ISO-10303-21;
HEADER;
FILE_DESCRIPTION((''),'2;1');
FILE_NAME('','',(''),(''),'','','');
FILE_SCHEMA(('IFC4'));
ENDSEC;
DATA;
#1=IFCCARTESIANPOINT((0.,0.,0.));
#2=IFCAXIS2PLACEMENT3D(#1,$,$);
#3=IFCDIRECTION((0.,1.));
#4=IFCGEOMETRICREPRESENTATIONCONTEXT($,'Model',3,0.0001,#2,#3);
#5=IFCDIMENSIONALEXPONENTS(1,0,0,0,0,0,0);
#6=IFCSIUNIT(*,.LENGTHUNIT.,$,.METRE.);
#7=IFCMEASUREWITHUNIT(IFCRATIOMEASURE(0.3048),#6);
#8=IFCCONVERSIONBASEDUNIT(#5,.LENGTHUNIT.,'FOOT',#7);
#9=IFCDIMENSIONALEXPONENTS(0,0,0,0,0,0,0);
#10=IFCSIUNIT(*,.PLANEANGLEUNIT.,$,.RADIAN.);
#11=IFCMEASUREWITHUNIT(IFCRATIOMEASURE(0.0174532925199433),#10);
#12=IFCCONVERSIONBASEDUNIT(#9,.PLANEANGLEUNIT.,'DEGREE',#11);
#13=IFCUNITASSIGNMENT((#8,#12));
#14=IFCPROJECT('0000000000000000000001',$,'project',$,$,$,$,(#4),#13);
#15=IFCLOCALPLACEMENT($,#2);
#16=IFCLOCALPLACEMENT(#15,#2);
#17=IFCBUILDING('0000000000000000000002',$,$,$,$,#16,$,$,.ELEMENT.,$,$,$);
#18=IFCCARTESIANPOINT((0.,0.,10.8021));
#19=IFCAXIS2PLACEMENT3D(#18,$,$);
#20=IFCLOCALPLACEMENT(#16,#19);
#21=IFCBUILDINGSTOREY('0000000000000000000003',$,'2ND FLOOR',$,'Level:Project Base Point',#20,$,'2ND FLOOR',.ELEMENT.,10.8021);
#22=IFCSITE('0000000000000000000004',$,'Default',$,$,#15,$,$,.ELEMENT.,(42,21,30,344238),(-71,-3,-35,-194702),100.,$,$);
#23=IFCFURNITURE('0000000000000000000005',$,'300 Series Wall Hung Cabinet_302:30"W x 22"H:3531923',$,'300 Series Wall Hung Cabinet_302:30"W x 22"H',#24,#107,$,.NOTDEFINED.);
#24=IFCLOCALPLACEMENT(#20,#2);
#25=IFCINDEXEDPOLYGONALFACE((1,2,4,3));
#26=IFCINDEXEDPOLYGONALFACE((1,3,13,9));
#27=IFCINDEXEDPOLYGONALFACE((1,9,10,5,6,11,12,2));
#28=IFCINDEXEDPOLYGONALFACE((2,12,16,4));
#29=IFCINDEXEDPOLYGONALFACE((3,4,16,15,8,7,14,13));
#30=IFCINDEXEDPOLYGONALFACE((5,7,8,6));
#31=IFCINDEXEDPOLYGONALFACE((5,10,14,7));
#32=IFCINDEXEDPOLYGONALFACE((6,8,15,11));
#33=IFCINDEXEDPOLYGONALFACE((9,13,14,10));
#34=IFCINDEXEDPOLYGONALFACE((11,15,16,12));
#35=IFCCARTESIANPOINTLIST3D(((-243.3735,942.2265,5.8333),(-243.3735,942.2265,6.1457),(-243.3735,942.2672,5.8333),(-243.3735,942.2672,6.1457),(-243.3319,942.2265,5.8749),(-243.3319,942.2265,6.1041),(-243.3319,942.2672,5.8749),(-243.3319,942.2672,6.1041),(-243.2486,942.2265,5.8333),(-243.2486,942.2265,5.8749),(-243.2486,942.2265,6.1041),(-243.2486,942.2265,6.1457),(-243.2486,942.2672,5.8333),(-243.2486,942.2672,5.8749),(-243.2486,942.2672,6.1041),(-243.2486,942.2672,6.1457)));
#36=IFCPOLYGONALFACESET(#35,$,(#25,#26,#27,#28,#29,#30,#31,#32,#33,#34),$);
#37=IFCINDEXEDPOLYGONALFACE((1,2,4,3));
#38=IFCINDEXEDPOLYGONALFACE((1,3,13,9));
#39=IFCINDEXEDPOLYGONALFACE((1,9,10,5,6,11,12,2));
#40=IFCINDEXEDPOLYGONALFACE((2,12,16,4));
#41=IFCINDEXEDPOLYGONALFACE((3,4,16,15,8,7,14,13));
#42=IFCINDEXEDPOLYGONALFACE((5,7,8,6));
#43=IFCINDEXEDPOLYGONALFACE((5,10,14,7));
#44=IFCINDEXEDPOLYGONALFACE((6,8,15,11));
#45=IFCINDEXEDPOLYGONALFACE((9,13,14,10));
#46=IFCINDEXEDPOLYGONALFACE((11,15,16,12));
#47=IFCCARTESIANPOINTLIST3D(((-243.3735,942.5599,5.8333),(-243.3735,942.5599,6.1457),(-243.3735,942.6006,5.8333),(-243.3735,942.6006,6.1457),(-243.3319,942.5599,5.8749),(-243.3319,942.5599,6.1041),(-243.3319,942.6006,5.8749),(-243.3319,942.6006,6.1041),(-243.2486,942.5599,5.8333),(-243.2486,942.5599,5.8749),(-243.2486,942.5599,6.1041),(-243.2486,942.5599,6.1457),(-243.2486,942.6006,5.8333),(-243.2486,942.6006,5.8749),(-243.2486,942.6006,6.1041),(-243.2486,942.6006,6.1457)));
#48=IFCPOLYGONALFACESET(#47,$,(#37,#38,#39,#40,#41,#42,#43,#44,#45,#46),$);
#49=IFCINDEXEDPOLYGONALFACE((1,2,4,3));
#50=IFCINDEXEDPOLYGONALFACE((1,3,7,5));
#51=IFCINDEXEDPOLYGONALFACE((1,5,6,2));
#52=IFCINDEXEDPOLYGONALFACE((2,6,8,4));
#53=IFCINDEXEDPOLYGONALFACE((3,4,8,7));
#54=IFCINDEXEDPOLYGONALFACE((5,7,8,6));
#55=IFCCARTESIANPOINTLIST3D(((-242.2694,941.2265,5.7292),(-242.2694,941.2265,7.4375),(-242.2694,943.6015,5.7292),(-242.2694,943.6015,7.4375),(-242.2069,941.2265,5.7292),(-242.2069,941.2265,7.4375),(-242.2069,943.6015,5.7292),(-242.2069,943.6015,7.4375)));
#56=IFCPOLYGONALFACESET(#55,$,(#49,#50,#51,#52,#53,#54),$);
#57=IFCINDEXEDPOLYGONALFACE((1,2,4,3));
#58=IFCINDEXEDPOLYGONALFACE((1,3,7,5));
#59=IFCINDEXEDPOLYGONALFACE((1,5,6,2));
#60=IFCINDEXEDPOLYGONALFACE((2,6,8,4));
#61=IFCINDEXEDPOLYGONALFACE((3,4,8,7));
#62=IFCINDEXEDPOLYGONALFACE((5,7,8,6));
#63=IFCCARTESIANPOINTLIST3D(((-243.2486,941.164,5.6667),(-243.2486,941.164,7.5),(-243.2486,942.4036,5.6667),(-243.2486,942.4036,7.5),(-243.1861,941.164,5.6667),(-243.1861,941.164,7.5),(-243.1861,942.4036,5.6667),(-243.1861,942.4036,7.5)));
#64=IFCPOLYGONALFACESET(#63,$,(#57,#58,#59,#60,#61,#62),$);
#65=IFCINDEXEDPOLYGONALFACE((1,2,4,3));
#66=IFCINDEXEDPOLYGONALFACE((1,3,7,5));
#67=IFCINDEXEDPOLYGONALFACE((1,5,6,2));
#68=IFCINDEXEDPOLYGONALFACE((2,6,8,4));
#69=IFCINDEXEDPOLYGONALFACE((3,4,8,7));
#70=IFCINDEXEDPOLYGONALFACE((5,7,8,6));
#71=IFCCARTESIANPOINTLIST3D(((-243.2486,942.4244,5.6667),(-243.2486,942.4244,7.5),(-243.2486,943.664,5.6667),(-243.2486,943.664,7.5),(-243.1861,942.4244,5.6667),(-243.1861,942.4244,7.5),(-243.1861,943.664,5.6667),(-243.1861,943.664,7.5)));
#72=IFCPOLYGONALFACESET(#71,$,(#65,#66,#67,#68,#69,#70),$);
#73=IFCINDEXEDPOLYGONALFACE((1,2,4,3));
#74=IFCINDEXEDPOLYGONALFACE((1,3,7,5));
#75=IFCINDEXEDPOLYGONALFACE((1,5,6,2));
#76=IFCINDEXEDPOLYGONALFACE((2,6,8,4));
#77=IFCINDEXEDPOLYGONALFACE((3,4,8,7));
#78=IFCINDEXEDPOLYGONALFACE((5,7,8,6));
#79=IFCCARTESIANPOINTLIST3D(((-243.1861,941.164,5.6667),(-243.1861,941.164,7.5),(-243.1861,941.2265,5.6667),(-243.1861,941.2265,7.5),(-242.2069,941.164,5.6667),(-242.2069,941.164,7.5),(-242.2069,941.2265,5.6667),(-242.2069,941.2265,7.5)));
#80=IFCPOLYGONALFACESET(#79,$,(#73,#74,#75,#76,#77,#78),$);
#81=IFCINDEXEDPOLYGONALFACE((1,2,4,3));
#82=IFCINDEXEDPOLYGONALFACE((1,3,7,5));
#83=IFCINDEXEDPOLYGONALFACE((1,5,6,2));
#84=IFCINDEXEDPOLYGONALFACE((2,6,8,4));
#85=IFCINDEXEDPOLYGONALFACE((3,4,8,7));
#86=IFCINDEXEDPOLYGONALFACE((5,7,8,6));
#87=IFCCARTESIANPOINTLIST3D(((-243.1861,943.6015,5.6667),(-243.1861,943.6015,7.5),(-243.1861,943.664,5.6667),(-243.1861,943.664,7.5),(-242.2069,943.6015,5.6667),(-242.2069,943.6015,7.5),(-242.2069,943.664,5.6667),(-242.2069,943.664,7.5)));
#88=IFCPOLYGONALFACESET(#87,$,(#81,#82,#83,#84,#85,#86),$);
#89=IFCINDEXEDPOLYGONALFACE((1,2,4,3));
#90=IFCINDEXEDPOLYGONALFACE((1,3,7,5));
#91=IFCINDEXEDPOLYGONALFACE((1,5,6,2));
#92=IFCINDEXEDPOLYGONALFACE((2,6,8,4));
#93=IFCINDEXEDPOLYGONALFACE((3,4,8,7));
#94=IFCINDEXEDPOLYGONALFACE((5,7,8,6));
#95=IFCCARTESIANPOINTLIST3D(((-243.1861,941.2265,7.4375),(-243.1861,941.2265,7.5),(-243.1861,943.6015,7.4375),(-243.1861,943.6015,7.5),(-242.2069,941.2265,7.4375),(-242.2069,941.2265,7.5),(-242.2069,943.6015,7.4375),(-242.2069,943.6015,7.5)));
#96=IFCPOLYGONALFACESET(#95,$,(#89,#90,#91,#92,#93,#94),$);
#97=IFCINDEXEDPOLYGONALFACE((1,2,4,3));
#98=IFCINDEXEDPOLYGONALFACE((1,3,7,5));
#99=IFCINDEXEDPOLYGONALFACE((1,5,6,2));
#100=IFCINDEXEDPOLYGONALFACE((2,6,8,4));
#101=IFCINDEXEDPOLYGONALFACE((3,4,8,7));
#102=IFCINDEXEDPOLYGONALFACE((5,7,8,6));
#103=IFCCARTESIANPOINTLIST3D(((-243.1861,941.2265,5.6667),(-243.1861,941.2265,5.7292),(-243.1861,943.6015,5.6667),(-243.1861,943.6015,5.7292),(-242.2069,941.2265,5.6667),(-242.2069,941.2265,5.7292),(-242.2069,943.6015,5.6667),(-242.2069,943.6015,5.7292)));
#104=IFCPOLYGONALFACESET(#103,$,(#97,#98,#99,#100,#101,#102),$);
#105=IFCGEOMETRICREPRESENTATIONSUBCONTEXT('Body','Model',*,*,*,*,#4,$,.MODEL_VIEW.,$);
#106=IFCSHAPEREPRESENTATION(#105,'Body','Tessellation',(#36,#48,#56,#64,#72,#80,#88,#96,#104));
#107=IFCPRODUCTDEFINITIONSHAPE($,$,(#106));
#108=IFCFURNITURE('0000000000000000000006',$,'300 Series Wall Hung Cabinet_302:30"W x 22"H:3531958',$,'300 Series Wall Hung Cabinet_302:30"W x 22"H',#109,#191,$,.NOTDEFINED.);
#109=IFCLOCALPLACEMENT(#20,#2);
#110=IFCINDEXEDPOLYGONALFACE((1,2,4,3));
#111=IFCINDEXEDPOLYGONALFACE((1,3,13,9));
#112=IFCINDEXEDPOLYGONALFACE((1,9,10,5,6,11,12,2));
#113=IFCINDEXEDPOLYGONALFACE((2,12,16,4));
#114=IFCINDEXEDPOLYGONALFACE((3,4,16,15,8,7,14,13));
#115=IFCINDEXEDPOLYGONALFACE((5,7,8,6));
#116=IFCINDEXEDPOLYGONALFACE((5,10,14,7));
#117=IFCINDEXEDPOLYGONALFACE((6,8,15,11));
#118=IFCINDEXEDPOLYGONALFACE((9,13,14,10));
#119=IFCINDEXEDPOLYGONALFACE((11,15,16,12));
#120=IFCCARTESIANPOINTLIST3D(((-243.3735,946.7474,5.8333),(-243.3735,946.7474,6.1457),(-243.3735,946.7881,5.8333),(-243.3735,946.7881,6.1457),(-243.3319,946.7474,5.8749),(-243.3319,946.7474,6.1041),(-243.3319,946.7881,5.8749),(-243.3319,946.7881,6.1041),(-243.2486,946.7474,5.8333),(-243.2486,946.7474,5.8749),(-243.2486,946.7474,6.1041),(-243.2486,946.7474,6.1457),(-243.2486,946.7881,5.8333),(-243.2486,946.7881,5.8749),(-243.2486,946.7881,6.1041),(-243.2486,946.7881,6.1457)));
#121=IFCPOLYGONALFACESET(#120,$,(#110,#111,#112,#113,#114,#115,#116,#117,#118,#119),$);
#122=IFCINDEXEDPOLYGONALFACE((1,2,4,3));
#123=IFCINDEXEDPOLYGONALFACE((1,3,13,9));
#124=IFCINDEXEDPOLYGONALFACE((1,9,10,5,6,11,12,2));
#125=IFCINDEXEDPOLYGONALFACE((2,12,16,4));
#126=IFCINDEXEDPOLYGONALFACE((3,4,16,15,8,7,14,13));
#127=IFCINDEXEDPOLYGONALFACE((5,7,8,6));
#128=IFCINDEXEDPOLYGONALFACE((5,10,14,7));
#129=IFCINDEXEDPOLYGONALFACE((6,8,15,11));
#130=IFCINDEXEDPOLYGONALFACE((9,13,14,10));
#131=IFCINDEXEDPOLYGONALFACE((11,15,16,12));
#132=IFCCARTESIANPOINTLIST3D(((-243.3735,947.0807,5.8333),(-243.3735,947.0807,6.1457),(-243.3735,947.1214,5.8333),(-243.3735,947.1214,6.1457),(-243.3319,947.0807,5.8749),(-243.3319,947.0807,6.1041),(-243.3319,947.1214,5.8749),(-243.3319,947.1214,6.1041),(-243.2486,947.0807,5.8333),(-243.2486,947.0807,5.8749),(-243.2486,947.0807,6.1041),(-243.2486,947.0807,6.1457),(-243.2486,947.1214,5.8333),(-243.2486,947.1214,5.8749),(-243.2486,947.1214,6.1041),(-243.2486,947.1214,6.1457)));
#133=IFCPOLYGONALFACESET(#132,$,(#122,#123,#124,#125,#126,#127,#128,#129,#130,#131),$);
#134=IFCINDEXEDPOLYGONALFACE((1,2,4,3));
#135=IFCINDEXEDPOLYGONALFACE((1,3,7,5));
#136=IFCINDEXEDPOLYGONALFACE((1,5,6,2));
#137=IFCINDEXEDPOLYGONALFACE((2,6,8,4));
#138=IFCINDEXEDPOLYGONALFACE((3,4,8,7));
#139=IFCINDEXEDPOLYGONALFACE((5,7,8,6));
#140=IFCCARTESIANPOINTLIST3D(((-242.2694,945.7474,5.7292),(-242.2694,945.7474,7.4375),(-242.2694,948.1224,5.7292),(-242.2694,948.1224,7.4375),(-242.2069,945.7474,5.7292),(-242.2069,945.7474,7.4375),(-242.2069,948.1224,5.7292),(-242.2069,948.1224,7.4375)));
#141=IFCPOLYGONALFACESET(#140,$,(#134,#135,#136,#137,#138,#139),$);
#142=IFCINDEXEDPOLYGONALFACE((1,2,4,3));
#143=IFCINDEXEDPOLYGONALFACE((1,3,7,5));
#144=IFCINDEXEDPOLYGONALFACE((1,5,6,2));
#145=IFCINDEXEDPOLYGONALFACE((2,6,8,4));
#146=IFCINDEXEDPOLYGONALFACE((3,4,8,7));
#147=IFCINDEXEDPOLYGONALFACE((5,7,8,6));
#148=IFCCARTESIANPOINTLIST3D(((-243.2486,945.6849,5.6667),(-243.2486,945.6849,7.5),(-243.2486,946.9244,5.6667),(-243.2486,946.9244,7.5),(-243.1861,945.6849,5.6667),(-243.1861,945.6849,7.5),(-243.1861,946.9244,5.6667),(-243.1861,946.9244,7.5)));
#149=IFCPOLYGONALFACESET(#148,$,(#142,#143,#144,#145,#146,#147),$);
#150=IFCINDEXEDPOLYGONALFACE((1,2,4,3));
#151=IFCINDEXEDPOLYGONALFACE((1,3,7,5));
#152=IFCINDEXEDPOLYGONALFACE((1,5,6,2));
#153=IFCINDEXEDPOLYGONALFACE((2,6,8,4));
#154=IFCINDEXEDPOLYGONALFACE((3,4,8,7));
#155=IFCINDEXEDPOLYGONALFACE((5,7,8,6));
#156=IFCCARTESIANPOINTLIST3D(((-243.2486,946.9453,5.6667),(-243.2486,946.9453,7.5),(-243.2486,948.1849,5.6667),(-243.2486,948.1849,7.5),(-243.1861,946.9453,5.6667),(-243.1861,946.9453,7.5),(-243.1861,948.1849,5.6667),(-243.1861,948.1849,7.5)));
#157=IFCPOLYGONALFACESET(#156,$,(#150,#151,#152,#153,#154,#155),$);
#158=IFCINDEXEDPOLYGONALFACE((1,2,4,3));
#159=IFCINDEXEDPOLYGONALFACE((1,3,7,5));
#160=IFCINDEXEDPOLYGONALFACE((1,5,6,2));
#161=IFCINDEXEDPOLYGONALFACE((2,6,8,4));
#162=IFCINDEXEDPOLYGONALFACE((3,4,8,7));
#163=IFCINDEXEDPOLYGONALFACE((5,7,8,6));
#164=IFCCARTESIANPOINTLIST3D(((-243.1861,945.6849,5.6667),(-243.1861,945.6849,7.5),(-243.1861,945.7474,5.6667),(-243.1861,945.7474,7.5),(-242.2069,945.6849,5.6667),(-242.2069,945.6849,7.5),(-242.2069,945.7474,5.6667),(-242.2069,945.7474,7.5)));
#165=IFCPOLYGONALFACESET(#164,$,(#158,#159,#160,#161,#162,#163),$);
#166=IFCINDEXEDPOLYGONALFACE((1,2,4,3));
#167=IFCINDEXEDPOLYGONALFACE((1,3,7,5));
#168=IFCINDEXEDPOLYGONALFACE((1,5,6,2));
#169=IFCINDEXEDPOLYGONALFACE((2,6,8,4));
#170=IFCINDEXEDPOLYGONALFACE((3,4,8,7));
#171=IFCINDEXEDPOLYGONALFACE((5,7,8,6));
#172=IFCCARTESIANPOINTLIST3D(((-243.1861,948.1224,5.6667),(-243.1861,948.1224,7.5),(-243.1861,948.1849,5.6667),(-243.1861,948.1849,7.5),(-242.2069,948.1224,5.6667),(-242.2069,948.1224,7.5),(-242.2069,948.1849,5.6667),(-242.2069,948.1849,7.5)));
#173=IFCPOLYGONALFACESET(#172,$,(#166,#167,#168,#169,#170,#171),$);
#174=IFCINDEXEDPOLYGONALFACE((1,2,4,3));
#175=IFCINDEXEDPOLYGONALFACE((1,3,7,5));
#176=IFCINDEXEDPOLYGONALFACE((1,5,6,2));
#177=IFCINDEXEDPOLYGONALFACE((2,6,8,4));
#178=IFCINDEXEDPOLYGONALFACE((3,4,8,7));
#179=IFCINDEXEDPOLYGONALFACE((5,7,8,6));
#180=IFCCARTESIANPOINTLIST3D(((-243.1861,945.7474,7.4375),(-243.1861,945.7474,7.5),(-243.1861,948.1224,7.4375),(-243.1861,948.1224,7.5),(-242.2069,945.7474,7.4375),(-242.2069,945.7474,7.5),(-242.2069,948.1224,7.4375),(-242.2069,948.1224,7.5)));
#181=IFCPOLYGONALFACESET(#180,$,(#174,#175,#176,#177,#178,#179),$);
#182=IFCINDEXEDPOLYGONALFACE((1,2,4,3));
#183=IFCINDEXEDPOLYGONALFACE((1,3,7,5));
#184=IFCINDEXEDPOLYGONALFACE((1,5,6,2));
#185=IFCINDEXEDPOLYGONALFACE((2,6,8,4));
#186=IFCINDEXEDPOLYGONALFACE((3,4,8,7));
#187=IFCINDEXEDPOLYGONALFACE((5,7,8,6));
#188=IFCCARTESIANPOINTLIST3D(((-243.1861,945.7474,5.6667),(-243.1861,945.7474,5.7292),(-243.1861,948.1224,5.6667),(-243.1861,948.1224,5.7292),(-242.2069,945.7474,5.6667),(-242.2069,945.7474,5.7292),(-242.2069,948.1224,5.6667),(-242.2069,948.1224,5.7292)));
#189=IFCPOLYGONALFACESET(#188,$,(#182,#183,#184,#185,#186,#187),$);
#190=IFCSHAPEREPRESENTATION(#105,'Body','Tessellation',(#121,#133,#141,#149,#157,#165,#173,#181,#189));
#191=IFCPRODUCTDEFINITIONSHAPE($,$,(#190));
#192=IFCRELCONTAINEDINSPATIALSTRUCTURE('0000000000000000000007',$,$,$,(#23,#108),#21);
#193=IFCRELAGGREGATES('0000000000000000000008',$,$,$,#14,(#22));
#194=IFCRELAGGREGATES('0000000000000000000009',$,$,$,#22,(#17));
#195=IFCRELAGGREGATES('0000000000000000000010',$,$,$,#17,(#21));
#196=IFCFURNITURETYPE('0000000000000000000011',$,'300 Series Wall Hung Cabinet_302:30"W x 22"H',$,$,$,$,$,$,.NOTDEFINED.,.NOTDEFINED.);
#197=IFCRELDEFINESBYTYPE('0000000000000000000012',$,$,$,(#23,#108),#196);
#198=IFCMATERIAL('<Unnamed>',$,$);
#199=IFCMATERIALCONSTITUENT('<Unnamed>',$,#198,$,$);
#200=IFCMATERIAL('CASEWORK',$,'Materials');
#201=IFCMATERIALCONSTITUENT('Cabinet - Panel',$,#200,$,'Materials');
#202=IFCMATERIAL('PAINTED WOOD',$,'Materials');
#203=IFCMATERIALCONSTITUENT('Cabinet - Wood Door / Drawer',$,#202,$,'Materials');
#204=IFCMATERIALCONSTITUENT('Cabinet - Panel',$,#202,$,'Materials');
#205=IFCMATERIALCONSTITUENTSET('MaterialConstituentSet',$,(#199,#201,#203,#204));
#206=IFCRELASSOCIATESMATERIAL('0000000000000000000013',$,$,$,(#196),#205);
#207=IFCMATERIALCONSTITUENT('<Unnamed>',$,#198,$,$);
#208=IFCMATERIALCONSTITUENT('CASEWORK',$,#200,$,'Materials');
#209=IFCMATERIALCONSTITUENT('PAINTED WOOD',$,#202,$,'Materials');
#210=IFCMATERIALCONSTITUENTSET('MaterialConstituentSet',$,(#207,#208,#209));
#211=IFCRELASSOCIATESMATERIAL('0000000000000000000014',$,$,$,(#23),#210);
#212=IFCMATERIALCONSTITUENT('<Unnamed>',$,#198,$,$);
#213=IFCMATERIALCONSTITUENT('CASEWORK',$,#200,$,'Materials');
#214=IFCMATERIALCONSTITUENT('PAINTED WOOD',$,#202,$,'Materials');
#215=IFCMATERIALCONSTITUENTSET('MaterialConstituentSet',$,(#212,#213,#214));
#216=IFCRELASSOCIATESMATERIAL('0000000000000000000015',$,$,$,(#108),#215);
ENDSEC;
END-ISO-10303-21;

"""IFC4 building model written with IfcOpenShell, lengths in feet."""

from ifc_helpers import new_model, entity, si_unit, converted_unit, direction, frame, frame_2d, origin, origin_2d_with_axis, place, context, subcontext, project, spatial, polyline, rectangle, outline, extrude, source, transform, mapped, material, constituent, constituent_set, type_object, type_shapes, element, save


model = new_model("IFC4")

# Units and contexts
model_context = context("Model", 3, precision=0.0001, world=origin(), true_north=direction((0.0, 1.0)))
body_context = subcontext(model_context, "Body", "Model", "MODEL_VIEW")
ifc_project = project(units=[converted_unit("LENGTHUNIT", "FOOT", entity("IfcRatioMeasure", 0.3048), si_unit("LENGTHUNIT", "METRE"), dimensions=[1, 0, 0, 0, 0, 0, 0]), converted_unit("PLANEANGLEUNIT", "DEGREE", entity("IfcRatioMeasure", 0.0174532925199433), si_unit("PLANEANGLEUNIT", "RADIAN"), dimensions=[0, 0, 0, 0, 0, 0, 0])], contexts=[model_context])

# Site, building, storey
site_placement = place(None, origin())
site = spatial("IfcSite", under=ifc_project, at=site_placement, Name="Default", CompositionType="ELEMENT", RefLatitude=(42, 21, 30, 344238), RefLongitude=(-71, -3, -35, -194702), RefElevation=100.0)
building_placement = place(site_placement, origin())
building = spatial("IfcBuilding", under=site, at=building_placement, CompositionType="ELEMENT")
storey_placement = place(building_placement, frame((0.0, 0.0, 10.8021)))
storey = spatial("IfcBuildingStorey", under=building, at=storey_placement, Name="2ND FLOOR", ObjectType="Level:Project Base Point", LongName="2ND FLOOR", CompositionType="ELEMENT", Elevation=10.8021)

# Furniture
ifc_material_1 = material(Name="CASEWORK", Category="Materials")
ifc_material_2 = material(Name="<Unnamed>")
ifc_constituent_1 = constituent(ifc_material_2, Name="<Unnamed>")
ifc_constituent_2 = constituent(ifc_material_1, Name="CASEWORK", Category="Materials")
ifc_material_3 = material(Name="PAINTED WOOD", Category="Materials")
ifc_constituent_3 = constituent(ifc_material_3, Name="PAINTED WOOD", Category="Materials")
ifc_constituent_set_1 = constituent_set(constituents=[ifc_constituent_1, ifc_constituent_2, ifc_constituent_3], Name="MaterialConstituentSet")
ifc_constituent_4 = constituent(ifc_material_2, Name="<Unnamed>")
ifc_constituent_5 = constituent(ifc_material_1, Name="Cabinet - Panel", Category="Materials")
ifc_constituent_6 = constituent(ifc_material_3, Name="Cabinet - Wood Door / Drawer", Category="Materials")
ifc_constituent_7 = constituent(ifc_material_3, Name="Cabinet - Panel", Category="Materials")
ifc_constituent_set_2 = constituent_set(constituents=[ifc_constituent_4, ifc_constituent_5, ifc_constituent_6, ifc_constituent_7], Name="MaterialConstituentSet")
furniture_type_1 = type_object("IfcFurnitureType", Name="300 Series Wall Hung Cabinet_302:30\"W x 22\"H", AssemblyPlace="NOTDEFINED", PredefinedType="NOTDEFINED", material=ifc_constituent_set_2)
shared_shape_1 = source(origin(), body_context, "Body", "SweptSolid", [
    extrude(outline(polyline([(-0.0521, -0.1146), (-0.0521, -0.1562), (0.0729, -0.1562), (0.0729, 0.1562), (-0.0521, 0.1562), (-0.0521, 0.1146), (0.0313, 0.1146), (0.0313, -0.1146), (-0.0521, -0.1146)])), frame((1.0625, 1.0937, 0.3229), z_axis=(-1.0, 0.0, 0.0), x_axis=(0.0, 1.0, 0.0)), (0.0, 0.0, -1.0), 0.0407),
    extrude(outline(polyline([(-0.0521, -0.1146), (-0.0521, -0.1562), (0.0729, -0.1562), (0.0729, 0.1562), (-0.0521, 0.1562), (-0.0521, 0.1146), (0.0313, 0.1146), (0.0313, -0.1146), (-0.0521, -0.1146)])), frame((1.3958, 1.0937, 0.3229), z_axis=(-1.0, 0.0, 0.0), x_axis=(0.0, 1.0, 0.0)), (0.0, 0.0, -1.0), 0.0407),
    extrude(rectangle(XDim=0.0625, YDim=2.375, at=frame_2d((0.0, 0.0), x_axis=(1.0, 0.0))), frame((1.25, 0.0313, 0.0625), z_axis=(0.0, 0.0, 1.0), x_axis=(0.0, 1.0, 0.0)), (0.0, 0.0, 1.0), 1.7083),
    extrude(rectangle(XDim=0.0625, YDim=1.2396, at=origin_2d_with_axis()), frame((0.6198, 1.0104, 0.0), z_axis=(0.0, 0.0, 1.0), x_axis=(0.0, 1.0, 0.0)), (0.0, 0.0, 1.0), 1.8333),
    extrude(rectangle(XDim=0.0625, YDim=1.2396, at=frame_2d((0.0, 0.0), x_axis=(1.0, 0.0))), frame((1.8802, 1.0104, 0.0), z_axis=(0.0, 0.0, 1.0), x_axis=(0.0, 1.0, 0.0)), (0.0, 0.0, 1.0), 1.8333),
    extrude(rectangle(XDim=0.0625, YDim=0.9792, at=frame_2d((0.0, 0.0), x_axis=(1.0, 0.0))), frame((0.0313, 0.4896, 0.0)), (0.0, 0.0, 1.0), 1.8333),
    extrude(rectangle(XDim=0.0625, YDim=0.9792, at=frame_2d((0.0, 0.0), x_axis=(1.0, 0.0))), frame((2.4688, 0.4896, 0.0)), (0.0, 0.0, 1.0), 1.8333),
    extrude(rectangle(XDim=2.375, YDim=0.9792, at=frame_2d((0.0, 0.0), x_axis=(1.0, 0.0))), frame((1.25, 0.4896, 1.7708), z_axis=(0.0, 0.0, 1.0), x_axis=(-1.0, 0.0, 0.0)), (0.0, 0.0, 1.0), 0.0625),
    extrude(rectangle(XDim=2.375, YDim=0.9792, at=frame_2d((0.0, 0.0), x_axis=(1.0, 0.0))), frame((1.25, 0.4896, 0.0), z_axis=(0.0, 0.0, 1.0), x_axis=(-1.0, 0.0, 0.0)), (0.0, 0.0, 1.0), 0.0625),
])
type_shapes(furniture_type_1, [shared_shape_1])
furniture_1_placement = place(storey_placement, frame((-242.2069, 941.164, 5.6667), z_axis=(0.0, 0.0, 1.0), x_axis=(0.0, 1.0, 0.0)))
element("IfcFurniture", 1, at=furniture_1_placement, inside=storey, type_object=furniture_type_1, material=ifc_constituent_set_1, Name="300 Series Wall Hung Cabinet_302:30\"W x 22\"H:3531923", ObjectType="300 Series Wall Hung Cabinet_302:30\"W x 22\"H", PredefinedType="NOTDEFINED", context=body_context, shape_type="MappedRepresentation", body=[
    mapped(shared_shape_1, transform((0.0, 0.0, 0.0), scale=1.0)),
])
ifc_constituent_8 = constituent(ifc_material_2, Name="<Unnamed>")
ifc_constituent_9 = constituent(ifc_material_1, Name="CASEWORK", Category="Materials")
ifc_constituent_10 = constituent(ifc_material_3, Name="PAINTED WOOD", Category="Materials")
ifc_constituent_set_3 = constituent_set(constituents=[ifc_constituent_8, ifc_constituent_9, ifc_constituent_10], Name="MaterialConstituentSet")
furniture_2_placement = place(storey_placement, frame((-242.2069, 945.6849, 5.6667), z_axis=(0.0, 0.0, 1.0), x_axis=(0.0, 1.0, 0.0)))
element("IfcFurniture", 2, at=furniture_2_placement, inside=storey, type_object=furniture_type_1, material=ifc_constituent_set_3, Name="300 Series Wall Hung Cabinet_302:30\"W x 22\"H:3531958", ObjectType="300 Series Wall Hung Cabinet_302:30\"W x 22\"H", PredefinedType="NOTDEFINED", context=body_context, shape_type="MappedRepresentation", body=[
    mapped(shared_shape_1, transform((0.0, 0.0, 0.0), scale=1.0)),
])

save(model, "model.ifc")
